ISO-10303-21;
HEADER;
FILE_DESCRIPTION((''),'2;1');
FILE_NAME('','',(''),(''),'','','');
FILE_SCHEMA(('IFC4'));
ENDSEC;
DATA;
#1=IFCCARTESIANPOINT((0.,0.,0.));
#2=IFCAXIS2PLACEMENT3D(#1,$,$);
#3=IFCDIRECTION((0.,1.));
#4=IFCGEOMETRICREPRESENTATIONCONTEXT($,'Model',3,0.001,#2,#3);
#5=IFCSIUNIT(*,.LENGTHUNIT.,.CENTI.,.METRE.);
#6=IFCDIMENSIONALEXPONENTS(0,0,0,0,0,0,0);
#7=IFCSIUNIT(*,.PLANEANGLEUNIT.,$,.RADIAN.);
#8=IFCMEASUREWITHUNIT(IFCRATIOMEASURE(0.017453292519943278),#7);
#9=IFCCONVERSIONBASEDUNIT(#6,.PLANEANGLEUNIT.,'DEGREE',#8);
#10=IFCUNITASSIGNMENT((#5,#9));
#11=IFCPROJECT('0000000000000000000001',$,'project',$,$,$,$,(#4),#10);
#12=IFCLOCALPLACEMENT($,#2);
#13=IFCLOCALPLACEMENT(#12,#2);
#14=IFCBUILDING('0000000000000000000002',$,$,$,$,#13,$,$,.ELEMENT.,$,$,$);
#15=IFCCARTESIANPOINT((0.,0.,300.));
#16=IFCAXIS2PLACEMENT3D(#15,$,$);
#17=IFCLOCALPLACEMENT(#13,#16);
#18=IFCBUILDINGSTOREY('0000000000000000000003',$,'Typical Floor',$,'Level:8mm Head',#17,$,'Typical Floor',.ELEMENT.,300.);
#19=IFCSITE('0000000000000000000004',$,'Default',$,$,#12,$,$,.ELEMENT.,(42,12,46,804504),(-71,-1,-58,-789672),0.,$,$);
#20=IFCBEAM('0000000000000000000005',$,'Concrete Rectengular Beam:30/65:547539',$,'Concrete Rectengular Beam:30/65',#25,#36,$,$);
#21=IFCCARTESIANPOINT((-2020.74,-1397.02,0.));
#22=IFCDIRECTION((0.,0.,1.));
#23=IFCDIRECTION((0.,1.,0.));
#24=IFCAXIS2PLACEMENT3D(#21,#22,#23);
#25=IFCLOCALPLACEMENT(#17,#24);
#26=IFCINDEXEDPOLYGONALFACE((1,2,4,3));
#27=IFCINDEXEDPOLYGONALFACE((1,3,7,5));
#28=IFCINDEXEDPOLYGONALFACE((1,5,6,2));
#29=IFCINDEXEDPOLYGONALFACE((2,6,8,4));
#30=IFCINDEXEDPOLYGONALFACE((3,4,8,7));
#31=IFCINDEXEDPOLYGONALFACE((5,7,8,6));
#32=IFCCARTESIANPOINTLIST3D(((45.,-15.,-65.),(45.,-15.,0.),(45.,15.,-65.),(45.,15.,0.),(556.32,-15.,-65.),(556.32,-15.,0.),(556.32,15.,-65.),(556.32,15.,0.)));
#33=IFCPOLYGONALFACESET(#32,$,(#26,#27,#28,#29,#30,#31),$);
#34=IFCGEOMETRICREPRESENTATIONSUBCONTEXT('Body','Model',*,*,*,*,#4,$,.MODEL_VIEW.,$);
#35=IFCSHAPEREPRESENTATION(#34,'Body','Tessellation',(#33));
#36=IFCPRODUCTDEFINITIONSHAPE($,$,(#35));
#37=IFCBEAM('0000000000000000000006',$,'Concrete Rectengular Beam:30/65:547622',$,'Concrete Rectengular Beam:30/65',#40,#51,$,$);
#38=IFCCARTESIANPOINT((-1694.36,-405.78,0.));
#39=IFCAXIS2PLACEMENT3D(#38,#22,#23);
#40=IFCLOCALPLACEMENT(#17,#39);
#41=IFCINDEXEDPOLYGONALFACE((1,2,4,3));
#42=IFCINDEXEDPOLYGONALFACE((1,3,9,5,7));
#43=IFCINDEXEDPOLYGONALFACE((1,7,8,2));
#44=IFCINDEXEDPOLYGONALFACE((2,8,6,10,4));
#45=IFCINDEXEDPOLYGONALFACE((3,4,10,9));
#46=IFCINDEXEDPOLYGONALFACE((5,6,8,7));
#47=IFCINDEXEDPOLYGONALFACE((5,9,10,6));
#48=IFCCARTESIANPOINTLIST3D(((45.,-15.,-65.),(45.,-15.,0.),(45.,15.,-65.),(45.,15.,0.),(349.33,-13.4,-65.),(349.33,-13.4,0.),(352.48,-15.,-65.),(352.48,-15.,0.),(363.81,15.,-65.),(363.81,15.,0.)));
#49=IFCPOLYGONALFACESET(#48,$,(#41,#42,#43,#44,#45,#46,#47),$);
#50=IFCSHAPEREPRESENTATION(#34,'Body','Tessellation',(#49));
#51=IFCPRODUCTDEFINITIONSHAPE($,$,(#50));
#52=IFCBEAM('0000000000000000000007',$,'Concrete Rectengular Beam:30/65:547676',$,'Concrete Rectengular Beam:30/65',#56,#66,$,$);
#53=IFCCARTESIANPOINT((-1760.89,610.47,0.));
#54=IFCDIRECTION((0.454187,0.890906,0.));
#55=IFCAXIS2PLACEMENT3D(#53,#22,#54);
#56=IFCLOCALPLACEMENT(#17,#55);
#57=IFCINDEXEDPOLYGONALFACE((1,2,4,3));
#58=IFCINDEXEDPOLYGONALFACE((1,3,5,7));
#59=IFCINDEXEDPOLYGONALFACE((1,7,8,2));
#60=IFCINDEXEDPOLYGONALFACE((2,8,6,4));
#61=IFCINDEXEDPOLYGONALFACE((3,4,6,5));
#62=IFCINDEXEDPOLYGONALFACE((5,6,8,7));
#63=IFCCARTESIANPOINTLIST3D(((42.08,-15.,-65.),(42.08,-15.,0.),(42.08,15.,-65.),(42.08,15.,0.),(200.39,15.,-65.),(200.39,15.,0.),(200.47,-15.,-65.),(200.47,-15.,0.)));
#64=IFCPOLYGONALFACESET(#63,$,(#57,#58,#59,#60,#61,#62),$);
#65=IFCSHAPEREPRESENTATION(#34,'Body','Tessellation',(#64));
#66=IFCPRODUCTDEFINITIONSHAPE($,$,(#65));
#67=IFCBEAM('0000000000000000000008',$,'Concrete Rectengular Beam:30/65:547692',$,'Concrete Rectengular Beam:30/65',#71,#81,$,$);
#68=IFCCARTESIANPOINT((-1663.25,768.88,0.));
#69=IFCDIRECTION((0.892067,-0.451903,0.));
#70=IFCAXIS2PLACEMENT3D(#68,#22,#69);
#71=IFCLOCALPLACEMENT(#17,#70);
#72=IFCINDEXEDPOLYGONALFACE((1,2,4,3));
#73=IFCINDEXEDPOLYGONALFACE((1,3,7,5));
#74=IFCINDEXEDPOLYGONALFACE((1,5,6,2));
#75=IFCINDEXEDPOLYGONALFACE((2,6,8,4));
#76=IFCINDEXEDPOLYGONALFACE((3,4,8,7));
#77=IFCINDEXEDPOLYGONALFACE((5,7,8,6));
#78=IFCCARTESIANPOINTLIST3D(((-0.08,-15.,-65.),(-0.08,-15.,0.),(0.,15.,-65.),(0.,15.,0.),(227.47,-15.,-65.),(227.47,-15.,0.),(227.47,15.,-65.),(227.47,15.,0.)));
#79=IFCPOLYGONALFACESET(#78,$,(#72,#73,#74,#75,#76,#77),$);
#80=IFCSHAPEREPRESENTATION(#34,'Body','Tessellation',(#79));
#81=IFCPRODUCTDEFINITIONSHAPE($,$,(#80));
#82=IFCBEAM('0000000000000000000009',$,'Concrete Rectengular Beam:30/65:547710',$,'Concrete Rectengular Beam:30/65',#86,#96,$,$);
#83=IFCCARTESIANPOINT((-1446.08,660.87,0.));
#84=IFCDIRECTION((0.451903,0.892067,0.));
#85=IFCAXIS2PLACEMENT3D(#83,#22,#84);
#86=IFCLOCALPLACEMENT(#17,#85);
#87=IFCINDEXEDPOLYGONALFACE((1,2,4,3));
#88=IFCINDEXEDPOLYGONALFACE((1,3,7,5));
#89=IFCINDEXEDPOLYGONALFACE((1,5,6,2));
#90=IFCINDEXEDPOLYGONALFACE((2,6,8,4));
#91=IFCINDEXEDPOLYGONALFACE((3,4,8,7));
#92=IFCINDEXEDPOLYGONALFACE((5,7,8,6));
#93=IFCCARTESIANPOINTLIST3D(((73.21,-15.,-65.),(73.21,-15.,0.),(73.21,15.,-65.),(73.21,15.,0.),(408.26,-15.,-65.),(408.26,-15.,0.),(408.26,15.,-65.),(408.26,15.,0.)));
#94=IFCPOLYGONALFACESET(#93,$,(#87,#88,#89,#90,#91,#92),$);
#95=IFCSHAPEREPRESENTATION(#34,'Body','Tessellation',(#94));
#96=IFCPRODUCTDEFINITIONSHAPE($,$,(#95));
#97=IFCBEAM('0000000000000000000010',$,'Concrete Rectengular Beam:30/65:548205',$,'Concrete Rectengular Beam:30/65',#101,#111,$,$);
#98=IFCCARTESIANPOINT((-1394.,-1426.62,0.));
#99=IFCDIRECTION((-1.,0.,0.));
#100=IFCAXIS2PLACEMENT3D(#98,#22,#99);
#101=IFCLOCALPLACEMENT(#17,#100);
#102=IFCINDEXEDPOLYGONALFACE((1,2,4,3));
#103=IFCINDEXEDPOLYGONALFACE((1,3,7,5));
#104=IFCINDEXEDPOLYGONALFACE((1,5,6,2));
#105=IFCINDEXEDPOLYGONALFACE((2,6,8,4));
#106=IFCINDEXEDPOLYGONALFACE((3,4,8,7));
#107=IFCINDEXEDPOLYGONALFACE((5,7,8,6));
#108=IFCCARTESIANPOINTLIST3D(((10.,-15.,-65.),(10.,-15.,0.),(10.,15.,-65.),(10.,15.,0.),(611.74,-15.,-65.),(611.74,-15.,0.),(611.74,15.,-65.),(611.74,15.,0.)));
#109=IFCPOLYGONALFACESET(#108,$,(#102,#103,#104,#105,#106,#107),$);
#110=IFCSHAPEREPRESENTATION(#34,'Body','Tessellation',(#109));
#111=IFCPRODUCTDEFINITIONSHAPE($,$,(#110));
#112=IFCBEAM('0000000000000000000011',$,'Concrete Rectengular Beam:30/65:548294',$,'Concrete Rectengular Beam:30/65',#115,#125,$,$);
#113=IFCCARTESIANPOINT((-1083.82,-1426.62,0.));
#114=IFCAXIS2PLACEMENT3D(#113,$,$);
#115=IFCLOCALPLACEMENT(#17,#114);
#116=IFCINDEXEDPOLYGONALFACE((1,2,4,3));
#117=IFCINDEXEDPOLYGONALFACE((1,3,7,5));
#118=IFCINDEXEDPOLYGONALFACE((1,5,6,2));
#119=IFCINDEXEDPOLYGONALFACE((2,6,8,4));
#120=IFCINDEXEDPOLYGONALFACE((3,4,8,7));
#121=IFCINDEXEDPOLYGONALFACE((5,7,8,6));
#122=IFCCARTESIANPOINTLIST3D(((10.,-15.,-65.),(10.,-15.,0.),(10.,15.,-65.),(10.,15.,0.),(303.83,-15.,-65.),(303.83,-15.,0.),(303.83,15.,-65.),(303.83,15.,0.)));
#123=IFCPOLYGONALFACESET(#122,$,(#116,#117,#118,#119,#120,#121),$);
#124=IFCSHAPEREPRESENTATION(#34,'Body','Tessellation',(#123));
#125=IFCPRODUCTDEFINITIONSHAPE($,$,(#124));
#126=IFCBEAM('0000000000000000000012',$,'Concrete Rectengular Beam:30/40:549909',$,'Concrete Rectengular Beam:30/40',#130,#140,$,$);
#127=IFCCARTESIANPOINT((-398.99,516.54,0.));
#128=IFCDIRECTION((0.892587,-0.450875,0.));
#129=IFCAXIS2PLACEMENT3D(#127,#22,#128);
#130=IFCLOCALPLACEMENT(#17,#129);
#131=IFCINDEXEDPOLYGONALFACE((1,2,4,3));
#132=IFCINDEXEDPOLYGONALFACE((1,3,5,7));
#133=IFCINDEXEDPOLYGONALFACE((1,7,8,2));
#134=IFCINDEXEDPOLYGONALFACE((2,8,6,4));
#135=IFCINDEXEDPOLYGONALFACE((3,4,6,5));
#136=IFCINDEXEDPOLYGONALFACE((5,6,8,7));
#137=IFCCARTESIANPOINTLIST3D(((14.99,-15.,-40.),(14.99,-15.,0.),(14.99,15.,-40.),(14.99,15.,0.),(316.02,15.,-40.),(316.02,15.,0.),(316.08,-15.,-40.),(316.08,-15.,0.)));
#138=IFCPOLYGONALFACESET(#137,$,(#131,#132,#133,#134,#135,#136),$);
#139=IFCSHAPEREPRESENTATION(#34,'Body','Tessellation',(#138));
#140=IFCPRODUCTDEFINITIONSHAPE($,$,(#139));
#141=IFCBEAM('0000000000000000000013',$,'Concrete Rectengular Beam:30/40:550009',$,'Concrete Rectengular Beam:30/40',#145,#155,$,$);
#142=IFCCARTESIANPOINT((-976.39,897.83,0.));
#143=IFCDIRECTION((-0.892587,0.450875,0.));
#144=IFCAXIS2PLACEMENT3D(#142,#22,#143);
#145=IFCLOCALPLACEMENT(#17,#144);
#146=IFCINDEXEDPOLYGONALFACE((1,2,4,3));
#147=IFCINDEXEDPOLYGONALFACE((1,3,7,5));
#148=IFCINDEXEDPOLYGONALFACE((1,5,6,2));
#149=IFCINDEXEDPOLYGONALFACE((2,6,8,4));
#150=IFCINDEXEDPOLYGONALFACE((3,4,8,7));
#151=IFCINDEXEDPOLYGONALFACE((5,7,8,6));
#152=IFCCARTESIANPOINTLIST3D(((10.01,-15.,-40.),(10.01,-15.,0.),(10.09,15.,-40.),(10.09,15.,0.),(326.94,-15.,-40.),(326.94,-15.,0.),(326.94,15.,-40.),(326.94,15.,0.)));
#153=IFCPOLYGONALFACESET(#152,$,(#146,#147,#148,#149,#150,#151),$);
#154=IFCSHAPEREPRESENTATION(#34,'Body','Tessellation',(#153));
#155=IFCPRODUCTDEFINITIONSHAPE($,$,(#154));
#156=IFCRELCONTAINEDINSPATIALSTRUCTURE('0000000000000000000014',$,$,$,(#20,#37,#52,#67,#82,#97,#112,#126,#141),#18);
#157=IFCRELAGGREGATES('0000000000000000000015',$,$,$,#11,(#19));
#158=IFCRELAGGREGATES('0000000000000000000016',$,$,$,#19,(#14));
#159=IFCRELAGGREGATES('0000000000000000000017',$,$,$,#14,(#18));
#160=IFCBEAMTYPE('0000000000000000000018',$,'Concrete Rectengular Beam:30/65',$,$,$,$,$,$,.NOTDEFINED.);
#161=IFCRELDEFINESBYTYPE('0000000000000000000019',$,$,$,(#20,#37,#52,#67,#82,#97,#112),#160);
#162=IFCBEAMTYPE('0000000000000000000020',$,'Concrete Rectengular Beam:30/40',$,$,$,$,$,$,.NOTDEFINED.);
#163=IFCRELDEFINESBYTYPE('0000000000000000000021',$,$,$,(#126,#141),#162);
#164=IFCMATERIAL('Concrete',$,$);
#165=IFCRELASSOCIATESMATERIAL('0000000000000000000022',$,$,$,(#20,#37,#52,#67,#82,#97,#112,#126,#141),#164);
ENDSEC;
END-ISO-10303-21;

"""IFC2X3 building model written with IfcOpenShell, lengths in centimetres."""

from ifc_helpers import new_model, entity, si_unit, converted_unit, direction, frame, frame_2d, origin, place, context, subcontext, project, spatial, polyline, rectangle, extrude, clip, halfspace, bounded_halfspace, material, type_object, element, save


model = new_model("IFC2X3")

# Units and contexts
model_context = context("Model", 3, precision=0.001, world=origin(), true_north=direction((0.0, 1.0)))
body_context = subcontext(model_context, "Body", "Model", "MODEL_VIEW")
ifc_project = project(units=[si_unit("LENGTHUNIT", "METRE", prefix="CENTI"), converted_unit("PLANEANGLEUNIT", "DEGREE", entity("IfcRatioMeasure", 0.017453292519943278), si_unit("PLANEANGLEUNIT", "RADIAN"), dimensions=[0, 0, 0, 0, 0, 0, 0])], contexts=[model_context])

# Site, building, storey
site_placement = place(None, origin())
site = spatial("IfcSite", under=ifc_project, at=site_placement, Name="Default", CompositionType="ELEMENT", RefLatitude=(42, 12, 46, 804504), RefLongitude=(-71, -1, -58, -789672), RefElevation=0.0)
building_placement = place(site_placement, origin())
building = spatial("IfcBuilding", under=site, at=building_placement, CompositionType="ELEMENT")
storey_placement = place(building_placement, frame((0.0, 0.0, 300.0)))
storey = spatial("IfcBuildingStorey", under=building, at=storey_placement, Name="Typical Floor", ObjectType="Level:8mm Head", LongName="Typical Floor", CompositionType="ELEMENT", Elevation=300.0)

# Beams
ifc_material = material(Name="Concrete")
beam_type_1 = type_object("IfcBeamType", Name="Concrete Rectengular Beam:30/65", PredefinedType="NOTDEFINED")
beam_1_placement = place(storey_placement, frame((-2020.74, -1397.02, 0.0), z_axis=(0.0, 0.0, 1.0), x_axis=(0.0, 1.0, 0.0)))
element("IfcBeam", 1, at=beam_1_placement, inside=storey, type_object=beam_type_1, material=ifc_material, Name="Concrete Rectengular Beam:30/65:547539", ObjectType="Concrete Rectengular Beam:30/65", context=body_context, shape_type="SweptSolid", body=[
    extrude(rectangle(XDim=65.0, YDim=30.0, at=frame_2d((0.0, 0.0), x_axis=(1.0, 0.0))), frame((45.0, 0.0, -32.5), z_axis=(1.0, 0.0, 0.0), x_axis=(0.0, 0.0, -1.0)), (0.0, 0.0, 1.0), 511.32),
])
beam_2_placement = place(storey_placement, frame((-1694.36, -405.78, 0.0), z_axis=(0.0, 0.0, 1.0), x_axis=(0.0, 1.0, 0.0)))
element("IfcBeam", 2, at=beam_2_placement, inside=storey, type_object=beam_type_1, material=ifc_material, Name="Concrete Rectengular Beam:30/65:547622", ObjectType="Concrete Rectengular Beam:30/65", context=body_context, shape_type="SweptSolid", body=[
    clip(clip(extrude(rectangle(XDim=65.0, YDim=30.0, at=frame_2d((0.0, 0.0), x_axis=(1.0, 0.0))), frame((45.0, 0.0, -32.5), z_axis=(1.0, 0.0, 0.0), x_axis=(0.0, 0.0, -1.0)), (0.0, 0.0, 1.0), 318.81), bounded_halfspace(frame((349.33, -13.4, 0.0), z_axis=(0.454187, 0.890906, 0.0), x_axis=(0.0, 0.0, -1.0)), False, frame((45.0, 0.0, -32.5), z_axis=(1.0, 0.0, 0.0), x_axis=(0.0, 0.0, -1.0)), polyline([(32.5, -13.4), (-32.5, -13.4), (-32.5, -15.0), (-2.5, -15.0), (32.5, -15.0), (32.5, -13.4)]))), bounded_halfspace(frame((390.21, 66.78, 0.0), z_axis=(0.890906, -0.454187, 0.0), x_axis=(0.0, 0.0, -1.0)), False, frame((45.0, 0.0, -32.5), z_axis=(1.0, 0.0, 0.0), x_axis=(0.0, 0.0, -1.0)), polyline([(-32.5, -13.4), (32.5, -13.4), (32.5, 15.0), (-32.5, 15.0), (-32.5, -13.4)]))),
])
beam_3_placement = place(storey_placement, frame((-1760.89, 610.47, 0.0), z_axis=(0.0, 0.0, 1.0), x_axis=(0.454187, 0.890906, 0.0)))
element("IfcBeam", 3, at=beam_3_placement, inside=storey, type_object=beam_type_1, material=ifc_material, Name="Concrete Rectengular Beam:30/65:547676", ObjectType="Concrete Rectengular Beam:30/65", context=body_context, shape_type="SweptSolid", body=[
    clip(extrude(rectangle(XDim=65.0, YDim=30.0, at=frame_2d((0.0, 0.0), x_axis=(1.0, 0.0))), frame((42.08, 0.0, -32.5), z_axis=(1.0, 0.0, 0.0), x_axis=(0.0, 0.0, -1.0)), (0.0, 0.0, 1.0), 158.39), halfspace(frame((200.39, 17.47, 0.0), z_axis=(0.999997, 0.002563, 0.0), x_axis=(0.002563, -0.999997, 0.0)), False)),
])
beam_4_placement = place(storey_placement, frame((-1663.25, 768.88, 0.0), z_axis=(0.0, 0.0, 1.0), x_axis=(0.892067, -0.451903, 0.0)))
element("IfcBeam", 4, at=beam_4_placement, inside=storey, type_object=beam_type_1, material=ifc_material, Name="Concrete Rectengular Beam:30/65:547692", ObjectType="Concrete Rectengular Beam:30/65", context=body_context, shape_type="SweptSolid", body=[
    clip(extrude(rectangle(XDim=65.0, YDim=30.0, at=frame_2d((0.0, 0.0), x_axis=(1.0, 0.0))), frame((-0.08, 0.0, -32.5), z_axis=(1.0, 0.0, 0.0), x_axis=(0.0, 0.0, -1.0)), (0.0, 0.0, 1.0), 227.55), halfspace(frame((-0.08, -16.35, 0.0), z_axis=(-0.999997, 0.002563, 0.0), x_axis=(-0.002563, -0.999997, 0.0)), False)),
])
beam_5_placement = place(storey_placement, frame((-1446.08, 660.87, 0.0), z_axis=(0.0, 0.0, 1.0), x_axis=(0.451903, 0.892067, 0.0)))
element("IfcBeam", 5, at=beam_5_placement, inside=storey, type_object=beam_type_1, material=ifc_material, Name="Concrete Rectengular Beam:30/65:547710", ObjectType="Concrete Rectengular Beam:30/65", context=body_context, shape_type="SweptSolid", body=[
    extrude(rectangle(XDim=65.0, YDim=30.0, at=frame_2d((0.0, 0.0), x_axis=(1.0, 0.0))), frame((73.21, 0.0, -32.5), z_axis=(1.0, 0.0, 0.0), x_axis=(0.0, 0.0, -1.0)), (0.0, 0.0, 1.0), 335.05),
])
beam_6_placement = place(storey_placement, frame((-1394.0, -1426.62, 0.0), z_axis=(0.0, 0.0, 1.0), x_axis=(-1.0, 0.0, 0.0)))
element("IfcBeam", 6, at=beam_6_placement, inside=storey, type_object=beam_type_1, material=ifc_material, Name="Concrete Rectengular Beam:30/65:548205", ObjectType="Concrete Rectengular Beam:30/65", context=body_context, shape_type="SweptSolid", body=[
    extrude(rectangle(XDim=65.0, YDim=30.0, at=frame_2d((0.0, 0.0), x_axis=(1.0, 0.0))), frame((10.0, 0.0, -32.5), z_axis=(1.0, 0.0, 0.0), x_axis=(0.0, 0.0, -1.0)), (0.0, 0.0, 1.0), 601.74),
])
beam_7_placement = place(storey_placement, frame((-1083.82, -1426.62, 0.0)))
element("IfcBeam", 7, at=beam_7_placement, inside=storey, type_object=beam_type_1, material=ifc_material, Name="Concrete Rectengular Beam:30/65:548294", ObjectType="Concrete Rectengular Beam:30/65", context=body_context, shape_type="SweptSolid", body=[
    extrude(rectangle(XDim=65.0, YDim=30.0, at=frame_2d((0.0, 0.0), x_axis=(1.0, 0.0))), frame((10.0, 0.0, -32.5), z_axis=(1.0, 0.0, 0.0), x_axis=(0.0, 0.0, -1.0)), (0.0, 0.0, 1.0), 293.83),
])
beam_type_2 = type_object("IfcBeamType", Name="Concrete Rectengular Beam:30/40", PredefinedType="NOTDEFINED")
beam_8_placement = place(storey_placement, frame((-398.99, 516.54, 0.0), z_axis=(0.0, 0.0, 1.0), x_axis=(0.892587, -0.450875, 0.0)))
element("IfcBeam", 8, at=beam_8_placement, inside=storey, type_object=beam_type_2, material=ifc_material, Name="Concrete Rectengular Beam:30/40:549909", ObjectType="Concrete Rectengular Beam:30/40", context=body_context, shape_type="SweptSolid", body=[
    clip(extrude(rectangle(XDim=40.0, YDim=30.0, at=frame_2d((0.0, 0.0), x_axis=(1.0, 0.0))), frame((14.99, 0.0, -20.0), z_axis=(1.0, 0.0, 0.0), x_axis=(0.0, 0.0, -1.0)), (0.0, 0.0, 1.0), 301.08), halfspace(frame((316.58, -288.5, -300.0), z_axis=(0.999998, 0.001841, 0.0), x_axis=(0.001841, -0.999998, 0.0)), False)),
])
beam_9_placement = place(storey_placement, frame((-976.39, 897.83, 0.0), z_axis=(0.0, 0.0, 1.0), x_axis=(-0.892587, 0.450875, 0.0)))
element("IfcBeam", 9, at=beam_9_placement, inside=storey, type_object=beam_type_2, material=ifc_material, Name="Concrete Rectengular Beam:30/40:550009", ObjectType="Concrete Rectengular Beam:30/40", context=body_context, shape_type="SweptSolid", body=[
    clip(extrude(rectangle(XDim=40.0, YDim=30.0, at=frame_2d((0.0, 0.0), x_axis=(1.0, 0.0))), frame((10.01, 0.0, -20.0), z_axis=(1.0, 0.0, 0.0), x_axis=(0.0, 0.0, -1.0)), (0.0, 0.0, 1.0), 316.93), halfspace(frame((10.12, 25.31, -300.0), z_axis=(-0.999996, 0.002658, 0.0), x_axis=(0.002658, 0.999996, 0.0)), False)),
])

save(model, "model.ifc")
